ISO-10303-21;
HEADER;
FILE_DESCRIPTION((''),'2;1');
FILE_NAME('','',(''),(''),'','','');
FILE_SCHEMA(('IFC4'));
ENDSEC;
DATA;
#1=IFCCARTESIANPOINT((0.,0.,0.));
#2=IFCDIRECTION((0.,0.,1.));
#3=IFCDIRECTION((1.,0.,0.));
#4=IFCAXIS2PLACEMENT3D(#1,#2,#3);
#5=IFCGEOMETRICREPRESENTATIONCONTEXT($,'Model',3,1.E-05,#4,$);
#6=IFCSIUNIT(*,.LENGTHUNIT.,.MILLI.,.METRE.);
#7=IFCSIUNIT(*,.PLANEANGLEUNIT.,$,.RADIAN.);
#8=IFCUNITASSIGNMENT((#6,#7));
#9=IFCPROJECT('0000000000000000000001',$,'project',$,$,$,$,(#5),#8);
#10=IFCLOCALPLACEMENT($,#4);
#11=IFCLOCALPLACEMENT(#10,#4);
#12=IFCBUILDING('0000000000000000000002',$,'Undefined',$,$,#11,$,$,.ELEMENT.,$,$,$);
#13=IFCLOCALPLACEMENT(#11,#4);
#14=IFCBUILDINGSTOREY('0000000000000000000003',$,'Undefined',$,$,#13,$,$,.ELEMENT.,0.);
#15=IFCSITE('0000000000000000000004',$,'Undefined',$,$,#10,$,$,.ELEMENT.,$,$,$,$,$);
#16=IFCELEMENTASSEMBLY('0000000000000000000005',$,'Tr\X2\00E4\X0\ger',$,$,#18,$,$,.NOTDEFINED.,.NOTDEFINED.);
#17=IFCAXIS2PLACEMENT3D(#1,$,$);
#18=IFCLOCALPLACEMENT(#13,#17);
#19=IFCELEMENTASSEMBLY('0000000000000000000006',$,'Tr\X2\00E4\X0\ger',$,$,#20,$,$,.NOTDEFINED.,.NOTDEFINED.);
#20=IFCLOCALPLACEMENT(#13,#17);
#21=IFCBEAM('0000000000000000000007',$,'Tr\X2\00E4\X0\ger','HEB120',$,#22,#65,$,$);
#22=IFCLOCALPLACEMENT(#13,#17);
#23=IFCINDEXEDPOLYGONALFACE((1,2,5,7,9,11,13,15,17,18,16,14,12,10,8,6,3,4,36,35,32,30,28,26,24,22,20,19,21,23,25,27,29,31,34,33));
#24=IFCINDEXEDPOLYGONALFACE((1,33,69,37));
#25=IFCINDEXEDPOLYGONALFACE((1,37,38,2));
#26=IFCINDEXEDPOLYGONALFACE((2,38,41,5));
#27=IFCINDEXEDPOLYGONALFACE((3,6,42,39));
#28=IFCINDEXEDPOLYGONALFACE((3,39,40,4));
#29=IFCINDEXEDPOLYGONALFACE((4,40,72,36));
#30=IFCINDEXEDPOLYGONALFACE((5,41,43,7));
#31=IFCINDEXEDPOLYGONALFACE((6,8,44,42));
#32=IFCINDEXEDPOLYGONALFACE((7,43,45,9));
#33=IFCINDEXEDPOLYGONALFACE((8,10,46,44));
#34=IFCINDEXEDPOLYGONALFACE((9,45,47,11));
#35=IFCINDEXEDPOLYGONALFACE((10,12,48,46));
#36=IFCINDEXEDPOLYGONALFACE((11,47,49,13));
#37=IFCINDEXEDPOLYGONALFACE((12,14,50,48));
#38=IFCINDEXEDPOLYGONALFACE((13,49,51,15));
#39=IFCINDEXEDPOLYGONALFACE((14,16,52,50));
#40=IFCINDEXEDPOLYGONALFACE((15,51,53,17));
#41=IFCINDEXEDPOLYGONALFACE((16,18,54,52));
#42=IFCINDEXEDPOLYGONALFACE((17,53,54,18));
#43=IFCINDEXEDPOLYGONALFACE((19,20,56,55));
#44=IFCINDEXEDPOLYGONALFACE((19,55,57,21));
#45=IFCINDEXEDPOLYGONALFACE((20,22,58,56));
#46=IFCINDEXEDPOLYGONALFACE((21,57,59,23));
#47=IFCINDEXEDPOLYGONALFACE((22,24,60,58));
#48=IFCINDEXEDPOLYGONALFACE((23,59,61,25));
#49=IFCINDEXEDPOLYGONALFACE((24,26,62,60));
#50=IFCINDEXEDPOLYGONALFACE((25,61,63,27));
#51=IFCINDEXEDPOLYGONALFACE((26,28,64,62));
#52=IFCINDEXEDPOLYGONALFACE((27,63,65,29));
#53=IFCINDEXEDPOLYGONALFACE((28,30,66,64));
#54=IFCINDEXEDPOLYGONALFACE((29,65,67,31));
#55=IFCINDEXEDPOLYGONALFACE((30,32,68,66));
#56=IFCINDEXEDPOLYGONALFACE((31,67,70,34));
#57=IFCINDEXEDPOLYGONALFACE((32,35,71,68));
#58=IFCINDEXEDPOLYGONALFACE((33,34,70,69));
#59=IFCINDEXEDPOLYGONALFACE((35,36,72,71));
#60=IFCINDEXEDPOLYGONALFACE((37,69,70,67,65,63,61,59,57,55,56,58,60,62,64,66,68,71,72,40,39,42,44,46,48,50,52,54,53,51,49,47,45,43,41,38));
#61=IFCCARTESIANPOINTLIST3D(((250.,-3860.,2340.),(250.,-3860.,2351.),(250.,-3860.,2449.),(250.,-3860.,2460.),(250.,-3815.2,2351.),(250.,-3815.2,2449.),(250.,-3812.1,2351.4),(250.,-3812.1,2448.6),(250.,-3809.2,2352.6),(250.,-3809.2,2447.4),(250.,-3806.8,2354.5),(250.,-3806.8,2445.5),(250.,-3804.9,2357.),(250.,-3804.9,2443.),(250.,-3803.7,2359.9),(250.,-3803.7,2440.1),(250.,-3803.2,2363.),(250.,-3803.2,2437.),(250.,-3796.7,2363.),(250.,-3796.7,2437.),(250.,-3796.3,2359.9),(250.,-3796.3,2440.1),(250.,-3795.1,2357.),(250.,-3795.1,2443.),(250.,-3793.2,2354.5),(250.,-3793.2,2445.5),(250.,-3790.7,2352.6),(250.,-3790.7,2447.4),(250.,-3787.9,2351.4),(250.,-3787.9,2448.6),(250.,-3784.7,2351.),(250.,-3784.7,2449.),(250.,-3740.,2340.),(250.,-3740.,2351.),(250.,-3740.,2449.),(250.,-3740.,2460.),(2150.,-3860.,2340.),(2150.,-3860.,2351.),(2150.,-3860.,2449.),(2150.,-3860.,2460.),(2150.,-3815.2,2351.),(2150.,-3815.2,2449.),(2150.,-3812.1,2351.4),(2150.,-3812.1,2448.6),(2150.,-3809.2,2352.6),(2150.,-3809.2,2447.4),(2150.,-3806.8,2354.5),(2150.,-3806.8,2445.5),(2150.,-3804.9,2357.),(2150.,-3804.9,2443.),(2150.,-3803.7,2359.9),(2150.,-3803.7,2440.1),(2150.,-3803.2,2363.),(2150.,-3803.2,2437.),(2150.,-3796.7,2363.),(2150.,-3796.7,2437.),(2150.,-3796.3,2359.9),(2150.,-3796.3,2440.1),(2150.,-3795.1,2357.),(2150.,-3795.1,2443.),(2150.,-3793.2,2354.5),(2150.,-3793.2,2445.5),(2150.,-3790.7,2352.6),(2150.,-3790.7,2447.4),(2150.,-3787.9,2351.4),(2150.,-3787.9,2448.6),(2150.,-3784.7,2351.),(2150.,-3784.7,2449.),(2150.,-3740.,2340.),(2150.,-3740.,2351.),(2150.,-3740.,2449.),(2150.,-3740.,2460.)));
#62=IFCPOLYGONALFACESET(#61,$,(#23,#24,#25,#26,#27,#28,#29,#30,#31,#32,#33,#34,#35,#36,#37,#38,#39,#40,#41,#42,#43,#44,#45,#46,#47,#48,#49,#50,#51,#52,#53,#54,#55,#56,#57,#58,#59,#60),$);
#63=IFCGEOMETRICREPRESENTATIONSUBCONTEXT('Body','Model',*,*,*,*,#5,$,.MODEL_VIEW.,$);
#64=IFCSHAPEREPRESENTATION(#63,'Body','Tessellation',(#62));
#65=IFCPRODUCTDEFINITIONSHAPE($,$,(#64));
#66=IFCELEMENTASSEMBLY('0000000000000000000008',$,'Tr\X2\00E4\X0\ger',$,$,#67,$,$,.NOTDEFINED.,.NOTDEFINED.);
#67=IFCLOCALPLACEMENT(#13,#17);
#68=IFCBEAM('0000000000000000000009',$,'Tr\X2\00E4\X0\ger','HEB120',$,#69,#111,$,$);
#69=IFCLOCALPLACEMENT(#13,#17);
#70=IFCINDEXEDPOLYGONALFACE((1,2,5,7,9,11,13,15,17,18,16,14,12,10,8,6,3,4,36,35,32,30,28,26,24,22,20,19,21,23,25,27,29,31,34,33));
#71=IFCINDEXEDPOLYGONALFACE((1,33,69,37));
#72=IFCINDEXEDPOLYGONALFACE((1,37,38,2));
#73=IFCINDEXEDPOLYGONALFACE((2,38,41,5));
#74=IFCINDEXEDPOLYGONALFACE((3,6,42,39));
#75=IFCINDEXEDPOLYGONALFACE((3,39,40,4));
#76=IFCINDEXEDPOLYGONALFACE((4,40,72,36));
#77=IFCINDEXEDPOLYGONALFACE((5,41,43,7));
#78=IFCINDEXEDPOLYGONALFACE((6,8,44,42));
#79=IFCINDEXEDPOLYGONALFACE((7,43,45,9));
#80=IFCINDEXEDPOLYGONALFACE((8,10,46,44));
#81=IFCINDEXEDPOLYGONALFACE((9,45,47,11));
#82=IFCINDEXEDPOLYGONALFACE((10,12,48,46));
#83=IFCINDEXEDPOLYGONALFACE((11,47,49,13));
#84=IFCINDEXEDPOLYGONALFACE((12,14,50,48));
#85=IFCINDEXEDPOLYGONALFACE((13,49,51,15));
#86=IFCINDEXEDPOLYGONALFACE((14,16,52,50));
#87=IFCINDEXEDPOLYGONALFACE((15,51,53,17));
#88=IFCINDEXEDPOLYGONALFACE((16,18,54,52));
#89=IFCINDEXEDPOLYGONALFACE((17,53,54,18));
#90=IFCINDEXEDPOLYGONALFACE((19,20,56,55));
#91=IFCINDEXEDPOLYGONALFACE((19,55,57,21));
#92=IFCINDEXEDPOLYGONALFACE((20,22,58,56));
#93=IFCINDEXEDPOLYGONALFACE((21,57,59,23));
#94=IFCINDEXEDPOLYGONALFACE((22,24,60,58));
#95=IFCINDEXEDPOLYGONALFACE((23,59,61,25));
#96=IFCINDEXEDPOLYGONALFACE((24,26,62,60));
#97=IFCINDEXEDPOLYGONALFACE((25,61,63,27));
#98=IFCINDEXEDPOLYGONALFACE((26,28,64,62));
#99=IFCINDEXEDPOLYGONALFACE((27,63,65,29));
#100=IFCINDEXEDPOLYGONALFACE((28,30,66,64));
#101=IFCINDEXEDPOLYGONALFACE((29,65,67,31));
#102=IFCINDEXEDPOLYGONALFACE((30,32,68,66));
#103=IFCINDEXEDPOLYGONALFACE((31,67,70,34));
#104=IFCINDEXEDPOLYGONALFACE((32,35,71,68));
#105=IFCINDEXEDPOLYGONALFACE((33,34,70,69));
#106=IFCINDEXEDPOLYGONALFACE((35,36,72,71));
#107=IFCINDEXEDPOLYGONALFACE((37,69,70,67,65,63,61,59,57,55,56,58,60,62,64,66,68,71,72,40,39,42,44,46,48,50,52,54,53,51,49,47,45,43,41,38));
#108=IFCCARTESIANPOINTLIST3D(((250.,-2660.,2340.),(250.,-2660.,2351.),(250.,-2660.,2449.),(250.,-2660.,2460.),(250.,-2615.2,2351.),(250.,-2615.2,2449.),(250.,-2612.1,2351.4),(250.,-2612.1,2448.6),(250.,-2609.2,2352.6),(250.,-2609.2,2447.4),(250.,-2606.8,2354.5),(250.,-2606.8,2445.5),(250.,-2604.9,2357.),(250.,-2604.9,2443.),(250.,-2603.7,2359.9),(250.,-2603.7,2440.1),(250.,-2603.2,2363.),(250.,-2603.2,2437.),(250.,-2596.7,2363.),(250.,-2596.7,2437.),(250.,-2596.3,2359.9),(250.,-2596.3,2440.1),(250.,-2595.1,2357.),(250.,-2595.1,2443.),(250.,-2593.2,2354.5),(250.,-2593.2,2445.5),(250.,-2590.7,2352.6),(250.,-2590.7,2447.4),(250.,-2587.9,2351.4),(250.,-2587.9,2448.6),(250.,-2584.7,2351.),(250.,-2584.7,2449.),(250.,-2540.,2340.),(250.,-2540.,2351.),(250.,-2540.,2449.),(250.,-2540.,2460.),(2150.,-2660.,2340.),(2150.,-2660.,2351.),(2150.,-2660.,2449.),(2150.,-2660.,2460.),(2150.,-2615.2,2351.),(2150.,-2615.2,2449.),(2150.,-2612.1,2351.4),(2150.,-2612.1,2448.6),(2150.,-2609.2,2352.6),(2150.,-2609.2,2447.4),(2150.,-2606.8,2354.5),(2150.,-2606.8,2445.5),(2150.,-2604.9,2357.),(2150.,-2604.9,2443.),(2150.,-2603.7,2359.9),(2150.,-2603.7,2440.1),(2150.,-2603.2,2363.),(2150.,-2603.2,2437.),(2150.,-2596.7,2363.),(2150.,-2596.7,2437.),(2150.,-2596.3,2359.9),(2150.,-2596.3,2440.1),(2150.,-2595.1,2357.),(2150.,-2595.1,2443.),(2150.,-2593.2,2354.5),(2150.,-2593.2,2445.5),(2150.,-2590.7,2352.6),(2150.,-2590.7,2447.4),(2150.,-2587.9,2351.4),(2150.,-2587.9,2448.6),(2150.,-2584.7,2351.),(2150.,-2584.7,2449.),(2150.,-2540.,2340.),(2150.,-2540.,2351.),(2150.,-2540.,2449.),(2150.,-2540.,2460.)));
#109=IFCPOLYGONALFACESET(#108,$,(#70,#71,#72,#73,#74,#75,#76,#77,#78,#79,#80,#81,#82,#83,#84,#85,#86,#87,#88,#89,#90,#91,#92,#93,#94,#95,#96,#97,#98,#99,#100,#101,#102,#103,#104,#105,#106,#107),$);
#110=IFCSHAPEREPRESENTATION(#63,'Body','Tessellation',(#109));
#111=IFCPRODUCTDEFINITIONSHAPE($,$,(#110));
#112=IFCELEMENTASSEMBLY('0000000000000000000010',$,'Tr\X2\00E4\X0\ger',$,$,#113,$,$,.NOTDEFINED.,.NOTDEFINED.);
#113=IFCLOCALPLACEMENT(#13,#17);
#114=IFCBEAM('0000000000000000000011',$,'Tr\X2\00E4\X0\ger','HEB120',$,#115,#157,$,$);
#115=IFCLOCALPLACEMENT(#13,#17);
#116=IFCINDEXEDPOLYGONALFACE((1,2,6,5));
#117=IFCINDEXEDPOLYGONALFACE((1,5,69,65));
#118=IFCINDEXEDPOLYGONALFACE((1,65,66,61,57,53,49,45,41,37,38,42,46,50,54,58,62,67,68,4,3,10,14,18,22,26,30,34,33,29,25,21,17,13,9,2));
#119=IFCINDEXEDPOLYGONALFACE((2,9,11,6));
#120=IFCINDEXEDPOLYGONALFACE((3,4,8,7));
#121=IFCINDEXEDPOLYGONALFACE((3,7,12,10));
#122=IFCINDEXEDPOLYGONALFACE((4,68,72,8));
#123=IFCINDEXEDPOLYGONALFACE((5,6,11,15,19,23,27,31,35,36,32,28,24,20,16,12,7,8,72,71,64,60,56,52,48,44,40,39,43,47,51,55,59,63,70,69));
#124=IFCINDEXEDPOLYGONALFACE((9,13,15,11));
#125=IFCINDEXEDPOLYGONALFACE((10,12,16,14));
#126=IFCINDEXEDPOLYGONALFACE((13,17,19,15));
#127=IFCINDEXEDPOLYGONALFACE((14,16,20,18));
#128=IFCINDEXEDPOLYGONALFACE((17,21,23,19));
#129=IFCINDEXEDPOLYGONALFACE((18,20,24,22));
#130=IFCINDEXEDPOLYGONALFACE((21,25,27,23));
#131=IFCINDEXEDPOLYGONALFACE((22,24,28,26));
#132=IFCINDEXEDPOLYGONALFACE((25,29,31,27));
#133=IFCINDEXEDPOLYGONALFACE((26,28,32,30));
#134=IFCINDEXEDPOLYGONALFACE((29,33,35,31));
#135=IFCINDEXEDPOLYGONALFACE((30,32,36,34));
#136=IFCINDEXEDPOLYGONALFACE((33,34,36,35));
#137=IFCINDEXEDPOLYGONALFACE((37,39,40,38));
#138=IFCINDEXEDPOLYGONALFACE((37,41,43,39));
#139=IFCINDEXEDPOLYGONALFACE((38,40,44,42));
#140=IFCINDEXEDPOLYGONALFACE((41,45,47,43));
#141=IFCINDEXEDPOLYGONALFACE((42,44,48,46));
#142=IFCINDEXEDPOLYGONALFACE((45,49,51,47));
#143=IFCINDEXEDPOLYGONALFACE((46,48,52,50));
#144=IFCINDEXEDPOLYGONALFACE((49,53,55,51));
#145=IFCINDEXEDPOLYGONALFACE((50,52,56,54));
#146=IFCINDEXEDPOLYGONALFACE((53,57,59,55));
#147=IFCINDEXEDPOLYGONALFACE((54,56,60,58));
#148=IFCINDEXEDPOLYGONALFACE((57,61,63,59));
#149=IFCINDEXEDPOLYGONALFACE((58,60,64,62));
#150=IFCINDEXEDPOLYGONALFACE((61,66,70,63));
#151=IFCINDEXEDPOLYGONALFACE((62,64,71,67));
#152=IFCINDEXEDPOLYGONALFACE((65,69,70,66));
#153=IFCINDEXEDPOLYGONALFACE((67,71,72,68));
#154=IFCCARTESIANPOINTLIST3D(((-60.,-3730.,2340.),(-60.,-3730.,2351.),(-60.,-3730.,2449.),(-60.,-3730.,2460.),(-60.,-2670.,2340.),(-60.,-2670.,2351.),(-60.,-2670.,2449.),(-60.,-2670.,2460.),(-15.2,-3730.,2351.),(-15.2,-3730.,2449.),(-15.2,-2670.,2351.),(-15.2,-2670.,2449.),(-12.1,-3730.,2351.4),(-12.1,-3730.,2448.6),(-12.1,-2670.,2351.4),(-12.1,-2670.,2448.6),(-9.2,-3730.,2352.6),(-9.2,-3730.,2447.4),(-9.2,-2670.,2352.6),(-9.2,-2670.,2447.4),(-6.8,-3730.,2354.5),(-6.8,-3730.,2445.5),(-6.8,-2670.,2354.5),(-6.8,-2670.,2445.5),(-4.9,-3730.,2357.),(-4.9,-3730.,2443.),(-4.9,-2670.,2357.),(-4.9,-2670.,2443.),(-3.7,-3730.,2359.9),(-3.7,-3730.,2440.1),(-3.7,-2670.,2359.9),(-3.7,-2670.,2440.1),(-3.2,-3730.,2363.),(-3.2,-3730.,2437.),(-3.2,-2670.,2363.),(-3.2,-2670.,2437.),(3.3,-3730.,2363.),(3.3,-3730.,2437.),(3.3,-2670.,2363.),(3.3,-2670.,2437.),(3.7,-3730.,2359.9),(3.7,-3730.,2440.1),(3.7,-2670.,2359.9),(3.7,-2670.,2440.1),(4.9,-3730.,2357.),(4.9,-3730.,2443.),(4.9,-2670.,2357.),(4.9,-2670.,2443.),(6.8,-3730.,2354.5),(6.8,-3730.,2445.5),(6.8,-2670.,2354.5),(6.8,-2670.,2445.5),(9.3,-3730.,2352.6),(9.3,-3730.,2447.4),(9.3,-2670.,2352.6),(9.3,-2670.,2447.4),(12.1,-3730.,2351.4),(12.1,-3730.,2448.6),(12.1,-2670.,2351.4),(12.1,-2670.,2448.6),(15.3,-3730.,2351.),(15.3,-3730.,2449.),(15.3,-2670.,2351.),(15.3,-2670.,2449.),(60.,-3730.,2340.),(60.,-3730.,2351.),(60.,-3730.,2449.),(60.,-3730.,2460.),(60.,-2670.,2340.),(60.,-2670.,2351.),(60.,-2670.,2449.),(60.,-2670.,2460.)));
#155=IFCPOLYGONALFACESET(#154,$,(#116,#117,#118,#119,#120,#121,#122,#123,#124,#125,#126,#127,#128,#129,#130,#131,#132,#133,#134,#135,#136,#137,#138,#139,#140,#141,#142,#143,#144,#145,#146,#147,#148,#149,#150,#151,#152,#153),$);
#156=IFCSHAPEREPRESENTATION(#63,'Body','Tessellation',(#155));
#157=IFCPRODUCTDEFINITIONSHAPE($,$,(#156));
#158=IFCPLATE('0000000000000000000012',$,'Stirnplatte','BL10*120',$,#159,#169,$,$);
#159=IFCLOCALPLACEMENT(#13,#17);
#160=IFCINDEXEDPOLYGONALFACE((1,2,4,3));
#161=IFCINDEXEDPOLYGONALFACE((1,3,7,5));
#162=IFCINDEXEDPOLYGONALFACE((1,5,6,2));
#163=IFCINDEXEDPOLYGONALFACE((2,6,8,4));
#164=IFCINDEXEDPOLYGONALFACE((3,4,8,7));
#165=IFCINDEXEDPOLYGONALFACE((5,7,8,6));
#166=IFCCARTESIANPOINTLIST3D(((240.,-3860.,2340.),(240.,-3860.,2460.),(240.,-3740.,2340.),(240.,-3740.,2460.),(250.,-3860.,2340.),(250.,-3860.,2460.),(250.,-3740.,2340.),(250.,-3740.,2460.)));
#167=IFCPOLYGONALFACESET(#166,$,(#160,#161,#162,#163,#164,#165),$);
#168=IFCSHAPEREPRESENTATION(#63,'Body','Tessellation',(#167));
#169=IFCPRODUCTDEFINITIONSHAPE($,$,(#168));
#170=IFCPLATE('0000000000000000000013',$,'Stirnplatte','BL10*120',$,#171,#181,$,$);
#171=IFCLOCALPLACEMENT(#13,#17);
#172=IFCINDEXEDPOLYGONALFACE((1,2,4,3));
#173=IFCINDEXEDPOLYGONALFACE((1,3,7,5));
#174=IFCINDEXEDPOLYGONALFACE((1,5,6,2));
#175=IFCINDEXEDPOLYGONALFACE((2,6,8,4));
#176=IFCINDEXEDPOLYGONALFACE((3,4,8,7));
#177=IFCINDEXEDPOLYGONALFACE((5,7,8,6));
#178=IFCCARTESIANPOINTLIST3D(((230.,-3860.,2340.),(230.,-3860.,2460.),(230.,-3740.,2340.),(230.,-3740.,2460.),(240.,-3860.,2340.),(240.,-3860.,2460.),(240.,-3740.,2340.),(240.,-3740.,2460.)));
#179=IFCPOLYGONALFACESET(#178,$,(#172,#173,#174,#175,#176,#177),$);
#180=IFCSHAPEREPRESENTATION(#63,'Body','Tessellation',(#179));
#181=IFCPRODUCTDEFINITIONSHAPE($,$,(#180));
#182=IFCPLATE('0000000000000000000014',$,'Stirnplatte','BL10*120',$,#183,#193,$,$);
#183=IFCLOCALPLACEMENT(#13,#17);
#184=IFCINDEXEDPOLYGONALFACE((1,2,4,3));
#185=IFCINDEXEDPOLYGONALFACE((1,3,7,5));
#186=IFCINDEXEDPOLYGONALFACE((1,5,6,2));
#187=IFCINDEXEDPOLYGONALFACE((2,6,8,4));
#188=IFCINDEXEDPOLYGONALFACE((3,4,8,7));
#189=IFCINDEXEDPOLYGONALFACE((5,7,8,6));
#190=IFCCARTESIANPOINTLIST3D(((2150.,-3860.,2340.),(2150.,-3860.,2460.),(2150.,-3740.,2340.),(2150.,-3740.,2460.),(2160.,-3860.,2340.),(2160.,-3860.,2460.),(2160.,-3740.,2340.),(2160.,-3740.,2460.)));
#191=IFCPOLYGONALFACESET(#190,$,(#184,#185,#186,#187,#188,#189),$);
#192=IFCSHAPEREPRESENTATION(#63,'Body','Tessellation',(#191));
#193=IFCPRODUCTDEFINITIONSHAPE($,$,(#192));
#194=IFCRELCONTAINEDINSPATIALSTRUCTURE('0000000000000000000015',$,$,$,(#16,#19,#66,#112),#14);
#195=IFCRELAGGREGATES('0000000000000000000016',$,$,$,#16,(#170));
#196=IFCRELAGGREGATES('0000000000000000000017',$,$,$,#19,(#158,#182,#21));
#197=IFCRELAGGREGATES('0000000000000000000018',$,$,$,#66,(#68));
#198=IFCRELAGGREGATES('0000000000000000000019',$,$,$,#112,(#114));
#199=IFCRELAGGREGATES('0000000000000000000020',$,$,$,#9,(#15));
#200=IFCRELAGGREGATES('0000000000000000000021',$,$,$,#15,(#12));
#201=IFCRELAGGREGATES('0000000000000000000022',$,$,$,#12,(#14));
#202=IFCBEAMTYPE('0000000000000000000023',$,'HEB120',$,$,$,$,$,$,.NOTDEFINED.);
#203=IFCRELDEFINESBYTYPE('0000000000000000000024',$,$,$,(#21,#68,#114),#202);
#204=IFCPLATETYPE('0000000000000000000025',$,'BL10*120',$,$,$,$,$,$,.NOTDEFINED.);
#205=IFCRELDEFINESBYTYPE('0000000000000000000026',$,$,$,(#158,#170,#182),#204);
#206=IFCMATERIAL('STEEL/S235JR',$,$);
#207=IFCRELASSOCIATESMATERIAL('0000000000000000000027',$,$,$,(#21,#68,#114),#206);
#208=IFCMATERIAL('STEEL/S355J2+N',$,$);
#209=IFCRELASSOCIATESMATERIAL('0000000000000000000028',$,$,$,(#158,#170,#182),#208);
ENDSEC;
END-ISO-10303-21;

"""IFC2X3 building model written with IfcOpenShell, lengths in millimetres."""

from ifc_helpers import new_model, si_unit, frame, origin_with_axes, origin_2d_with_axis, place, context, subcontext, project, spatial, polyline, i_section, outline, extrude, clip, halfspace, material, type_object, element, aggregate, save


model = new_model("IFC2X3")

# Units and contexts
model_context = context("Model", 3, precision=1e-05, world=origin_with_axes())
body_context = subcontext(model_context, "Body", "Model", "MODEL_VIEW")
ifc_project = project(units=[si_unit("LENGTHUNIT", "METRE", prefix="MILLI"), si_unit("PLANEANGLEUNIT", "RADIAN")], contexts=[model_context])

# Site, building, storey
site_placement = place(None, origin_with_axes())
site = spatial("IfcSite", under=ifc_project, at=site_placement, Name="Undefined", CompositionType="ELEMENT")
building_placement = place(site_placement, origin_with_axes())
building = spatial("IfcBuilding", under=site, at=building_placement, Name="Undefined", CompositionType="ELEMENT")
storey_placement = place(building_placement, origin_with_axes())
storey = spatial("IfcBuildingStorey", under=building, at=storey_placement, Name="Undefined", CompositionType="ELEMENT", Elevation=0.0)

# Element assemblies, beams
assembly_1_placement = place(storey_placement, origin_with_axes())
assembly_1 = element("IfcElementAssembly", 1, at=assembly_1_placement, inside=storey, Name="Träger", AssemblyPlace="NOTDEFINED", PredefinedType="NOTDEFINED")
ifc_material_1 = material(Name="STEEL/S235JR")
beam_type = type_object("IfcBeamType", Name="HEB120", PredefinedType="NOTDEFINED")
assembly_2_placement = place(storey_placement, origin_with_axes())
assembly_2 = element("IfcElementAssembly", 2, at=assembly_2_placement, inside=storey, Name="Träger", AssemblyPlace="NOTDEFINED", PredefinedType="NOTDEFINED")
beam_1_placement = place(assembly_2_placement, frame((250.0, -3800.0, 2400.0), z_axis=(0.0, 0.0, 1.0), x_axis=(1.0, 0.0, 0.0)))
beam_1 = element("IfcBeam", 3, at=beam_1_placement, type_object=beam_type, material=ifc_material_1, Name="Träger", Description="HEB120", context=body_context, shape_type="Clipping", body=[
    clip(clip(extrude(i_section(OverallWidth=120.0, OverallDepth=120.0, WebThickness=6.5, FlangeThickness=11.0, FilletRadius=12.0, at=origin_2d_with_axis()), frame((1910.0, 0.0, 0.0), z_axis=(-1.0, 0.0, 0.0), x_axis=(0.0, -1.0, 0.0)), (0.0, 0.0, 1.0), 1910.0), halfspace(frame((1900.0, 0.0, -60.0), z_axis=(-1.0, 0.0, 0.0), x_axis=(0.0, 1.0, 0.0)), True)), halfspace(frame((0.0, 0.0, -60.0), z_axis=(1.0, 0.0, 0.0), x_axis=(0.0, -1.0, 0.0)), True)),
])
assembly_3_placement = place(storey_placement, origin_with_axes())
assembly_3 = element("IfcElementAssembly", 4, at=assembly_3_placement, inside=storey, Name="Träger", AssemblyPlace="NOTDEFINED", PredefinedType="NOTDEFINED")
beam_2_placement = place(assembly_3_placement, frame((250.0, -2600.0, 2400.0), z_axis=(0.0, 0.0, 1.0), x_axis=(1.0, 0.0, 0.0)))
beam_2 = element("IfcBeam", 5, at=beam_2_placement, type_object=beam_type, material=ifc_material_1, Name="Träger", Description="HEB120", context=body_context, shape_type="Clipping", body=[
    clip(clip(extrude(i_section(OverallWidth=120.0, OverallDepth=120.0, WebThickness=6.5, FlangeThickness=11.0, FilletRadius=12.0, at=origin_2d_with_axis()), frame((1910.0, 0.0, 0.0), z_axis=(-1.0, 0.0, 0.0), x_axis=(0.0, -1.0, 0.0)), (0.0, 0.0, 1.0), 1910.0), halfspace(frame((1900.0, 0.0, -60.0), z_axis=(-1.0, 0.0, 0.0), x_axis=(0.0, 1.0, 0.0)), True)), halfspace(frame((0.0, 0.0, -60.0), z_axis=(1.0, 0.0, 0.0), x_axis=(0.0, -1.0, 0.0)), True)),
])
assembly_4_placement = place(storey_placement, origin_with_axes())
assembly_4 = element("IfcElementAssembly", 6, at=assembly_4_placement, inside=storey, Name="Träger", AssemblyPlace="NOTDEFINED", PredefinedType="NOTDEFINED")
beam_3_placement = place(assembly_4_placement, frame((0.0, -2670.0, 2400.0), z_axis=(0.0, 0.0, 1.0), x_axis=(0.0, -1.0, 0.0)))
beam_3 = element("IfcBeam", 7, at=beam_3_placement, type_object=beam_type, material=ifc_material_1, Name="Träger", Description="HEB120", context=body_context, shape_type="Clipping", body=[
    clip(clip(extrude(i_section(OverallWidth=120.0, OverallDepth=120.0, WebThickness=6.5, FlangeThickness=11.0, FilletRadius=12.0, at=origin_2d_with_axis()), frame((1060.0, 0.0, 0.0), z_axis=(-1.0, 0.0, 0.0), x_axis=(0.0, -1.0, 0.0)), (0.0, 0.0, 1.0), 1060.0), halfspace(frame((1060.0, 0.0, -60.0), z_axis=(-1.0, 0.0, 0.0), x_axis=(0.0, 1.0, 0.0)), True)), halfspace(frame((0.0, 0.0, -60.0), z_axis=(1.0, 0.0, 0.0), x_axis=(0.0, -1.0, 0.0)), True)),
])

# Plates
ifc_material_2 = material(Name="STEEL/S355J2+N")
plate_type = type_object("IfcPlateType", Name="BL10*120", PredefinedType="NOTDEFINED")
plate_1_placement = place(assembly_2_placement, frame((245.0, -3800.0, 2340.0), z_axis=(1.0, 0.0, 0.0), x_axis=(0.0, 0.0, 1.0)))
plate_1 = element("IfcPlate", 8, at=plate_1_placement, type_object=plate_type, material=ifc_material_2, Name="Stirnplatte", Description="BL10*120", context=body_context, shape_type="SweptSolid", body=[
    extrude(outline(polyline([(0.0, -60.0), (0.0, 60.0), (120.0, 60.0), (120.0, -60.0), (0.0, -60.0)])), frame((0.0, 0.0, -5.0), z_axis=(0.0, 0.0, 1.0), x_axis=(1.0, 0.0, 0.0)), (0.0, 0.0, 1.0), 10.0),
])
plate_2_placement = place(assembly_1_placement, frame((235.0, -3800.0, 2340.0), z_axis=(1.0, 0.0, 0.0), x_axis=(0.0, 0.0, 1.0)))
plate_2 = element("IfcPlate", 9, at=plate_2_placement, type_object=plate_type, material=ifc_material_2, Name="Stirnplatte", Description="BL10*120", context=body_context, shape_type="SweptSolid", body=[
    extrude(outline(polyline([(0.0, -60.0), (0.0, 60.0), (120.0, 60.0), (120.0, -60.0), (0.0, -60.0)])), frame((0.0, 0.0, -5.0), z_axis=(0.0, 0.0, 1.0), x_axis=(1.0, 0.0, 0.0)), (0.0, 0.0, 1.0), 10.0),
])
plate_3_placement = place(assembly_2_placement, frame((2155.0, -3800.0, 2340.0), z_axis=(-1.0, 0.0, 0.0), x_axis=(0.0, 0.0, 1.0)))
plate_3 = element("IfcPlate", 10, at=plate_3_placement, type_object=plate_type, material=ifc_material_2, Name="Stirnplatte", Description="BL10*120", context=body_context, shape_type="SweptSolid", body=[
    extrude(outline(polyline([(0.0, -60.0), (0.0, 60.0), (120.0, 60.0), (120.0, -60.0), (0.0, -60.0)])), frame((0.0, 0.0, -5.0), z_axis=(0.0, 0.0, 1.0), x_axis=(1.0, 0.0, 0.0)), (0.0, 0.0, 1.0), 10.0),
])

aggregate(assembly_1, [plate_2])
aggregate(assembly_2, [plate_1, plate_3, beam_1])
aggregate(assembly_3, [beam_2])

aggregate(assembly_4, [beam_3])

save(model, "model.ifc")
